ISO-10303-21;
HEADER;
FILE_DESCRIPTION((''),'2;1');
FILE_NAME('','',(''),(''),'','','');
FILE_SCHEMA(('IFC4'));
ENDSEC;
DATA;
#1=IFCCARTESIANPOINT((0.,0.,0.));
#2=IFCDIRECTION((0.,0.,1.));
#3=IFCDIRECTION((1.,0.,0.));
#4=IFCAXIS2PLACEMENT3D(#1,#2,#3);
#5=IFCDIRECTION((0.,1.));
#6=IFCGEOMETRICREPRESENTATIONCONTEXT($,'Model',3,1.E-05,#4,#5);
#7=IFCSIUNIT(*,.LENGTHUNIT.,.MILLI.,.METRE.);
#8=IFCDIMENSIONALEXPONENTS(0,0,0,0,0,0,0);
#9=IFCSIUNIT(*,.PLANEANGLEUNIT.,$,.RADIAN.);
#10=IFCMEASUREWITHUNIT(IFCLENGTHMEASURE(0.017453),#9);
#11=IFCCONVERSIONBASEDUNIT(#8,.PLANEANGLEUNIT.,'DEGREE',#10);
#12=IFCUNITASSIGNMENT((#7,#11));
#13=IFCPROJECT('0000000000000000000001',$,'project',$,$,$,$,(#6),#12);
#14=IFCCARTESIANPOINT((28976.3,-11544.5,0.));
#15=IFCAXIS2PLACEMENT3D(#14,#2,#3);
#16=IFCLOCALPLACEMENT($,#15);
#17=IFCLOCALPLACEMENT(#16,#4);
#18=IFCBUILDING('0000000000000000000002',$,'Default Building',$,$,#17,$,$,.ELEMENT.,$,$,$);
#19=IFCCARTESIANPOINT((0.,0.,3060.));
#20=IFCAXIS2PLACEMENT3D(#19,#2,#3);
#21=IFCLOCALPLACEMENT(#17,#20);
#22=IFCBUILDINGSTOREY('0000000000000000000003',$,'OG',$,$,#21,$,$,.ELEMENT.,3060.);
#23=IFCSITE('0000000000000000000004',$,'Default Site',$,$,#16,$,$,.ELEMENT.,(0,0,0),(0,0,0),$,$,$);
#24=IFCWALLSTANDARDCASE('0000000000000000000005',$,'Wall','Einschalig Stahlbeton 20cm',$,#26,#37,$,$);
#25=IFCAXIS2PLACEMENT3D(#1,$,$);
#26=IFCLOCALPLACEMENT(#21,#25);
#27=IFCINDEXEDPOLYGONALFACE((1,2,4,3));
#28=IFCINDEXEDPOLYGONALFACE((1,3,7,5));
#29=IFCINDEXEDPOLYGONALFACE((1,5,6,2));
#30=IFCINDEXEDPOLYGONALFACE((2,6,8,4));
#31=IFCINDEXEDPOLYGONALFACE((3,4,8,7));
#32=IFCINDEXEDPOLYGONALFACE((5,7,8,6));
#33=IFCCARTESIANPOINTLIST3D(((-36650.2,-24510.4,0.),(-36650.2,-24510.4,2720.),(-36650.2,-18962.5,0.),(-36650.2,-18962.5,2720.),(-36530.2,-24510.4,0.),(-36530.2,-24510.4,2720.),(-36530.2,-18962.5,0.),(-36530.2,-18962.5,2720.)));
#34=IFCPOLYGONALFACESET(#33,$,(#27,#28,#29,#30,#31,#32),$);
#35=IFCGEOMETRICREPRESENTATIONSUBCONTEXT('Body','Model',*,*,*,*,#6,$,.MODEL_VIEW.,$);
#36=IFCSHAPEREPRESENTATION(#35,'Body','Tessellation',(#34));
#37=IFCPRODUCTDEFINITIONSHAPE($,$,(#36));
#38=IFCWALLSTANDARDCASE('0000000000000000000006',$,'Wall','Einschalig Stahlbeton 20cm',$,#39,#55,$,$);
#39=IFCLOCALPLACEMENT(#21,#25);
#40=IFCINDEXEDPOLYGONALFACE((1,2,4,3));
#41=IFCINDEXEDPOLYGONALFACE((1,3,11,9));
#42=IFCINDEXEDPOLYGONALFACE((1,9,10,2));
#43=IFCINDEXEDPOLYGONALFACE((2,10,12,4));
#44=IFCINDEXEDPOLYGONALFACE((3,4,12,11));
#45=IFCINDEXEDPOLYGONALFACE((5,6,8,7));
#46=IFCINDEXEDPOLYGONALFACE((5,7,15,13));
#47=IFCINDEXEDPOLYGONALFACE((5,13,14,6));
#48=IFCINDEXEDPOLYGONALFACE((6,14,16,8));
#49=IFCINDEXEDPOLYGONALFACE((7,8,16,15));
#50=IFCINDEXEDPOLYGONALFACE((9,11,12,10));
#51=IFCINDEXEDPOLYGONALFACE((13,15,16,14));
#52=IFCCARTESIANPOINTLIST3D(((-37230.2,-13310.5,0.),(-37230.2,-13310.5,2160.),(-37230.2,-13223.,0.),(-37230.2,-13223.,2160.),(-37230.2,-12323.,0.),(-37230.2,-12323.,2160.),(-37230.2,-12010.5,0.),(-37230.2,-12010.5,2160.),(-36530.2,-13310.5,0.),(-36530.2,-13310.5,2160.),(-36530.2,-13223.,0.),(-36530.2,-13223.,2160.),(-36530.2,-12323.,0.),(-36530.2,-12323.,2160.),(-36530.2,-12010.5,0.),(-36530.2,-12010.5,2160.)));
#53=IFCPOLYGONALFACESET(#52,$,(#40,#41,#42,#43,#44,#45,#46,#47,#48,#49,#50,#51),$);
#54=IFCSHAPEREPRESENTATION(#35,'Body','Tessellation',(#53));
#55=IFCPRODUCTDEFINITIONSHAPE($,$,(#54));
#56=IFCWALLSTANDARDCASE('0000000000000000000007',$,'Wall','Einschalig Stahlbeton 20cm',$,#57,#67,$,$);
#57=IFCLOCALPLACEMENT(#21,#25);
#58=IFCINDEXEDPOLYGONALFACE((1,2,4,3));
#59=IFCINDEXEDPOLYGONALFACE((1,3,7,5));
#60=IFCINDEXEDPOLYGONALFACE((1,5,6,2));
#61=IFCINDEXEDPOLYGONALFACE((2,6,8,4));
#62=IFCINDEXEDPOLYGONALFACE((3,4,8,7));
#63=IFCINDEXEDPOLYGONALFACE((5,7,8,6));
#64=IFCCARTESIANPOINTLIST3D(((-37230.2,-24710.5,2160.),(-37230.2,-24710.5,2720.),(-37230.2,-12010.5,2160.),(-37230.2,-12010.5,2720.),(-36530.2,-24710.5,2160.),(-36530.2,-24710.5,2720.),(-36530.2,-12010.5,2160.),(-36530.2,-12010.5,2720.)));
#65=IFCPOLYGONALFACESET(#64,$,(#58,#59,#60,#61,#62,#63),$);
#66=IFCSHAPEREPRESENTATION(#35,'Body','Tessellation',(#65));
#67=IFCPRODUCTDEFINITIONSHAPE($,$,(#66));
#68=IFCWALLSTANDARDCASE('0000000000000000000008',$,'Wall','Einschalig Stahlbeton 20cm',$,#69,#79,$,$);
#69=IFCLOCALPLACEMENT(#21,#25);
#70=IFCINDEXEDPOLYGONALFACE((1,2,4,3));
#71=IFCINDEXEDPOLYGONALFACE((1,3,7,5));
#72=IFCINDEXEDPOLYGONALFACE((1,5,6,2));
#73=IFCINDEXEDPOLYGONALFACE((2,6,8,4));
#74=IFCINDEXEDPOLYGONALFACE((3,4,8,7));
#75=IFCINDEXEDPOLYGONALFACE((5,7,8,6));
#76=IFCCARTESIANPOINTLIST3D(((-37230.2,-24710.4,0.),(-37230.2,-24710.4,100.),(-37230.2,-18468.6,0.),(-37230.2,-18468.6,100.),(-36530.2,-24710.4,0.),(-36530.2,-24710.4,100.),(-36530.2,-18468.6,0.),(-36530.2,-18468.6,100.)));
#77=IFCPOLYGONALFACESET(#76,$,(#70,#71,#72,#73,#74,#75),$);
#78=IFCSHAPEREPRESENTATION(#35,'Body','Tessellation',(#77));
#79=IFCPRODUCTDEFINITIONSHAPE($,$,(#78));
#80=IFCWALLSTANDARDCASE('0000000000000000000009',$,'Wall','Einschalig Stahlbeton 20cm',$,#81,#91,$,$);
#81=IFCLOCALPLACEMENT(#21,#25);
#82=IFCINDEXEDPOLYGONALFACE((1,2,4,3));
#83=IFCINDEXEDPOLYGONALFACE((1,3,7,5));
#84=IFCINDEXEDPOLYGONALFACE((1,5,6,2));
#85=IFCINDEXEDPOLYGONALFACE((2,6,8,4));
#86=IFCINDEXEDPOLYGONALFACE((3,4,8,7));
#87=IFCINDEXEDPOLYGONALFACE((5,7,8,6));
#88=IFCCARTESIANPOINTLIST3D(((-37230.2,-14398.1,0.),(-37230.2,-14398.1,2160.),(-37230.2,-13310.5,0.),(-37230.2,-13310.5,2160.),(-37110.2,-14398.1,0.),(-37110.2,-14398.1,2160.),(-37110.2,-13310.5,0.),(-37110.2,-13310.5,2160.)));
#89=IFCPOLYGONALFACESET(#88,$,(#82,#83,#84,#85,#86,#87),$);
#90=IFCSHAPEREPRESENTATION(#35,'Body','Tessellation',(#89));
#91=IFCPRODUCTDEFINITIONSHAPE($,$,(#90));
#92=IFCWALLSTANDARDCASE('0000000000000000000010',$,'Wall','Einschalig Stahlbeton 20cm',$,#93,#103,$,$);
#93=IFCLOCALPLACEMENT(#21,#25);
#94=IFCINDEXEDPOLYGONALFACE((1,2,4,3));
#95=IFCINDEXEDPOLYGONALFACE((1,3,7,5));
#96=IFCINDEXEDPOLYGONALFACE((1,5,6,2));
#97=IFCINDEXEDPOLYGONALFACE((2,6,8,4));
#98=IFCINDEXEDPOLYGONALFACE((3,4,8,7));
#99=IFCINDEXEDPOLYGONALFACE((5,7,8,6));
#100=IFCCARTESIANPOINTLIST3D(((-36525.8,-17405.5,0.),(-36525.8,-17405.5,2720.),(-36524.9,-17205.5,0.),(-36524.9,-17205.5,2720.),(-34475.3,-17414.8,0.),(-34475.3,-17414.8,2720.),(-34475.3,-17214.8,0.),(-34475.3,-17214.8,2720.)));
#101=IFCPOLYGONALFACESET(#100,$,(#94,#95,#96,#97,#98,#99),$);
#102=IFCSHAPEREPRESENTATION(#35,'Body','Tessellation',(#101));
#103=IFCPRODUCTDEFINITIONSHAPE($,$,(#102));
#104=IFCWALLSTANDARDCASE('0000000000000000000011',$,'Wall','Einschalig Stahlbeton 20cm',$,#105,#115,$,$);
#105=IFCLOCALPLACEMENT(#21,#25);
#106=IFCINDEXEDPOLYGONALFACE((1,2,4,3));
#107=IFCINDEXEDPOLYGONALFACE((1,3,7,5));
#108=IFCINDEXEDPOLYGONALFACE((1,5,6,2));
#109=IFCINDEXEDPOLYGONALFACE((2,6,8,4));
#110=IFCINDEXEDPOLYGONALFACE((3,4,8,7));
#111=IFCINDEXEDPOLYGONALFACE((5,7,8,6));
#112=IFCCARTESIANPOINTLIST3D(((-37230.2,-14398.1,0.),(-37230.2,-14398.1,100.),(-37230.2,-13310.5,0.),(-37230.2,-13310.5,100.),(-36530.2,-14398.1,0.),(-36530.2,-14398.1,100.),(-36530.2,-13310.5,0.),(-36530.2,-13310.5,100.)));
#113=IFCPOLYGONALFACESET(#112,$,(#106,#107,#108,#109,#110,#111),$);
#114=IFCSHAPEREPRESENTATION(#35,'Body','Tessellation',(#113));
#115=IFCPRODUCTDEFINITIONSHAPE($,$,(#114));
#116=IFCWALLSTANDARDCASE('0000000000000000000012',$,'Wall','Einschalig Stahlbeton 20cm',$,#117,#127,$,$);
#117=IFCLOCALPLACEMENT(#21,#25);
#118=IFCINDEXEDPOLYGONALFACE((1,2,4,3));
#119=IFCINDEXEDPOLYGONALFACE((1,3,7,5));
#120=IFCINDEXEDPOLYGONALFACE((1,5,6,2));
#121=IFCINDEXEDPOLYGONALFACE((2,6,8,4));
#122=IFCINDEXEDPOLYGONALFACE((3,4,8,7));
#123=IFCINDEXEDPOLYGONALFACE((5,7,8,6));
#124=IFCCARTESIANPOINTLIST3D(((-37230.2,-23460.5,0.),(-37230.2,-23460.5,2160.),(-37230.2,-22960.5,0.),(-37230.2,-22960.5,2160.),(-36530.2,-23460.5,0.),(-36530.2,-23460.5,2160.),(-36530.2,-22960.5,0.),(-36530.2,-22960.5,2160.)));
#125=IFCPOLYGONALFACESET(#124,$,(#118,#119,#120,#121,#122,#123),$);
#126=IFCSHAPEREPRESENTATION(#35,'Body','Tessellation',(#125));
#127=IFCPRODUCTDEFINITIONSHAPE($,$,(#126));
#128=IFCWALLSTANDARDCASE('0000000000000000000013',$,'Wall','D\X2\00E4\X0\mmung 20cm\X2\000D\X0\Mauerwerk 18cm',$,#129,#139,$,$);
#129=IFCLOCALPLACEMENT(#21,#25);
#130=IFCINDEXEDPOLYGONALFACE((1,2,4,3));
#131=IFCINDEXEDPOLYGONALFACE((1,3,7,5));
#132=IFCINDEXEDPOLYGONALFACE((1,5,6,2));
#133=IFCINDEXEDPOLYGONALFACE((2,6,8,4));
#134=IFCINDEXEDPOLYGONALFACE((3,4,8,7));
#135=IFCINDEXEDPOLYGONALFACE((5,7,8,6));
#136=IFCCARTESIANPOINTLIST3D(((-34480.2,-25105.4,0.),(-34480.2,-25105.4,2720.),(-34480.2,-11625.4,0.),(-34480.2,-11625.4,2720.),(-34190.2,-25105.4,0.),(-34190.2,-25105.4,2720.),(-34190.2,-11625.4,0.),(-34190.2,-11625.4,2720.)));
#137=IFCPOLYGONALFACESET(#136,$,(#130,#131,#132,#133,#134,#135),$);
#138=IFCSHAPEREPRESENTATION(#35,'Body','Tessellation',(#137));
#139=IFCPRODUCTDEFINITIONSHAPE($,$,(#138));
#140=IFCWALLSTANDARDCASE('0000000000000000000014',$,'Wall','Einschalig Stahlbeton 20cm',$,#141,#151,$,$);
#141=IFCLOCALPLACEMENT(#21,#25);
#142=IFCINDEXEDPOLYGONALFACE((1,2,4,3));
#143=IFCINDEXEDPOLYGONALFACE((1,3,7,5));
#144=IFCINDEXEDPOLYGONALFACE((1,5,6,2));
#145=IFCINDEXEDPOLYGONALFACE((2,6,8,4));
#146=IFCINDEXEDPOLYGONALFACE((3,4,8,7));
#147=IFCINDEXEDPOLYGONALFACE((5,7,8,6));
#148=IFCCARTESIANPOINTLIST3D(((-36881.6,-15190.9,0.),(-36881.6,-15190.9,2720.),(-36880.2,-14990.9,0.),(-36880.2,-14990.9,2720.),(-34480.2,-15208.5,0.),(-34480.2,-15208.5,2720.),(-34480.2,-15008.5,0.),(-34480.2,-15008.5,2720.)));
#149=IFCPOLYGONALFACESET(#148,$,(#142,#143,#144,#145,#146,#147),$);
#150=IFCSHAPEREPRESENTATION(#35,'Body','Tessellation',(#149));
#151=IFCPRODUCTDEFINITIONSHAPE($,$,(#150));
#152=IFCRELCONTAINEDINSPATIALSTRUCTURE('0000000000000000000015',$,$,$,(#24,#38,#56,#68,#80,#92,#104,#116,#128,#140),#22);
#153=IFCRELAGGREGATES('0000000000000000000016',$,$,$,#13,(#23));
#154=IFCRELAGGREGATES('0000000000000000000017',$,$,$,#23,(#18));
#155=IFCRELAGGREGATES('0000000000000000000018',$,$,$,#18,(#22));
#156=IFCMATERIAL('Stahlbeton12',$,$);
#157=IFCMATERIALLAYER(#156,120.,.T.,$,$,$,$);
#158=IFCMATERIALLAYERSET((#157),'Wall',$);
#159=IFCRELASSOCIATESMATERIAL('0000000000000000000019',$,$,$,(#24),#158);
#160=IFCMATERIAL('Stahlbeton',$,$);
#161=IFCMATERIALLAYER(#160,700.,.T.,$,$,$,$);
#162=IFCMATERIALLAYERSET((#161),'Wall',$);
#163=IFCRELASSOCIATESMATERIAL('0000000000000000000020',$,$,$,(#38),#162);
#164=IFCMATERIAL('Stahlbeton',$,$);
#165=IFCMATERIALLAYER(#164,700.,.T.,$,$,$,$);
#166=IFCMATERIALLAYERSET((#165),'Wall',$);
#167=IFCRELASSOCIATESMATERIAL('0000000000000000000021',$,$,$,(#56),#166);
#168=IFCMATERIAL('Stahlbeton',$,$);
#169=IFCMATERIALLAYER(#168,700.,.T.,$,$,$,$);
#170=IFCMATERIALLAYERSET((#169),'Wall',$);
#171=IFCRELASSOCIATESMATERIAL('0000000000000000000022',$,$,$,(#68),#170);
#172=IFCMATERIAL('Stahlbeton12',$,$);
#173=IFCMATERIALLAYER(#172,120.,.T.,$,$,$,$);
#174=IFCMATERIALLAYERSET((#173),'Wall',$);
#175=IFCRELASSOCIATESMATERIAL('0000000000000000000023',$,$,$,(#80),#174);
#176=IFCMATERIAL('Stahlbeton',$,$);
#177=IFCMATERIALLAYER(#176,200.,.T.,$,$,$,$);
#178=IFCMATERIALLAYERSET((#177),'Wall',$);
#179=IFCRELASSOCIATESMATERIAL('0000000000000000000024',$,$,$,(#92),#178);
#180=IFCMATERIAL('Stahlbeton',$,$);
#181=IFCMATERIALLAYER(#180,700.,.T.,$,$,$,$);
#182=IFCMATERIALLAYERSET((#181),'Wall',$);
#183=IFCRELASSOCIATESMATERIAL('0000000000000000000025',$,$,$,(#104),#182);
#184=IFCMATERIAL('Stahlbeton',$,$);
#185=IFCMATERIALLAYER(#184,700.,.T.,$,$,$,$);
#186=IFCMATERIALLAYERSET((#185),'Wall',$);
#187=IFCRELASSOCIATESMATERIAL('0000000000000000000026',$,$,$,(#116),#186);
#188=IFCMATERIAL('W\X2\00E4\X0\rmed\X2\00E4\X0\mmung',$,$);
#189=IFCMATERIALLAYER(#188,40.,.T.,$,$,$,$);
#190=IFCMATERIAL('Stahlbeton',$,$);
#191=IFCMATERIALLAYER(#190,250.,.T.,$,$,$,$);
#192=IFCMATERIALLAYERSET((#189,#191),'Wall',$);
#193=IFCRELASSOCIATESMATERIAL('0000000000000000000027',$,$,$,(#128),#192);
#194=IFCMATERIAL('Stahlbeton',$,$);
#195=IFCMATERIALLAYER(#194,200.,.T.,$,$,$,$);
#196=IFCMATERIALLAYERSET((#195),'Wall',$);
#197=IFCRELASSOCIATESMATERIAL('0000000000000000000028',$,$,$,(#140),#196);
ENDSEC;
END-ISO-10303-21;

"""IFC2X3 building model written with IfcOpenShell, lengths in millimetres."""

from ifc_helpers import new_model, entity, si_unit, converted_unit, direction, frame, origin_with_axes, place, context, subcontext, project, spatial, polyline, outline, extrude, material, layer, layer_set, layer_usage, element, save


model = new_model("IFC2X3")

# Units and contexts
model_context = context("Model", 3, precision=1e-05, world=origin_with_axes(), true_north=direction((0.0, 1.0)))
body_context = subcontext(model_context, "Body", "Model", "MODEL_VIEW")
ifc_project = project(units=[si_unit("LENGTHUNIT", "METRE", prefix="MILLI"), converted_unit("PLANEANGLEUNIT", "DEGREE", entity("IfcLengthMeasure", 0.017453), si_unit("PLANEANGLEUNIT", "RADIAN"), dimensions=[0, 0, 0, 0, 0, 0, 0])], contexts=[model_context])

# Site, building, storey
site_placement = place(None, frame((28976.3, -11544.5, 0.0), z_axis=(0.0, 0.0, 1.0), x_axis=(1.0, 0.0, 0.0)))
site = spatial("IfcSite", under=ifc_project, at=site_placement, Name="Default Site", CompositionType="ELEMENT", RefLatitude=(0, 0, 0), RefLongitude=(0, 0, 0))
building_placement = place(site_placement, origin_with_axes())
building = spatial("IfcBuilding", under=site, at=building_placement, Name="Default Building", CompositionType="ELEMENT")
storey_placement = place(building_placement, frame((0.0, 0.0, 3060.0), z_axis=(0.0, 0.0, 1.0), x_axis=(1.0, 0.0, 0.0)))
storey = spatial("IfcBuildingStorey", under=building, at=storey_placement, Name="OG", CompositionType="ELEMENT", Elevation=3060.0)

# Wall
ifc_material_1 = material(Name="Stahlbeton12")
ifc_layer_1 = layer(ifc_material_1, 120.0, ventilated=True)
ifc_layer_set_1 = layer_set([ifc_layer_1], Name="Wall")
ifc_layer_usage_1 = layer_usage(ifc_layer_set_1, "AXIS2", "POSITIVE", -60.0)
wall_1_placement = place(storey_placement, frame((-36590.2, -24510.4, 0.0), z_axis=(0.0, 0.0, 1.0), x_axis=(0.0, 1.0, 0.0)))
element("IfcWallStandardCase", 1, at=wall_1_placement, inside=storey, material=ifc_layer_usage_1, Name="Wall", Description="Einschalig Stahlbeton 20cm", context=body_context, shape_type="SweptSolid", body=[
    extrude(outline(polyline([(0.0, -60.0), (0.0, 60.0), (5548.0, 60.0), (5548.0, -60.0), (0.0, -60.0)])), origin_with_axes(), (0.0, 0.0, 1.0), 2720.0),
])

# Wall, opening
ifc_material_2 = material(Name="Stahlbeton")
ifc_layer_2 = layer(ifc_material_2, 700.0, ventilated=True)
ifc_layer_set_2 = layer_set([ifc_layer_2], Name="Wall")
ifc_layer_usage_2 = layer_usage(ifc_layer_set_2, "AXIS2", "POSITIVE", -350.0)
wall_2_placement = place(storey_placement, frame((-36880.2, -13310.5, 0.0), z_axis=(0.0, 0.0, 1.0), x_axis=(0.0, 1.0, 0.0)))
wall_2 = element("IfcWallStandardCase", 2, at=wall_2_placement, inside=storey, material=ifc_layer_usage_2, Name="Wall", Description="Einschalig Stahlbeton 20cm", context=body_context, shape_type="SweptSolid", body=[
    extrude(outline(polyline([(0.0, -350.0), (0.0, 350.0), (1300.0, 350.0), (1300.0, -350.0), (0.0, -350.0)])), origin_with_axes(), (0.0, 0.0, 1.0), 2160.0),
])
opening_1_placement = place(wall_2_placement, frame((987.5, 0.0, 0.0), z_axis=(0.0, -1.0, 0.0), x_axis=(0.0, 0.0, 1.0)))
element("IfcOpeningElement", 3, at=opening_1_placement, cuts=wall_2, context=body_context, shape_type="SweptSolid", body=[
    extrude(outline(polyline([(0.0, 0.0), (2160.0, 0.0), (2160.0, 900.0), (0.0, 900.0), (0.0, 0.0), (0.0, 0.0)])), frame((0.0, 0.0, 700.0), z_axis=(0.0, 0.0, 1.0), x_axis=(1.0, 0.0, 0.0)), (0.0, 0.0, -1.0), 1400.0),
])

# Walls
ifc_material_3 = material(Name="Stahlbeton")
ifc_layer_3 = layer(ifc_material_3, 700.0, ventilated=True)
ifc_layer_set_3 = layer_set([ifc_layer_3], Name="Wall")
ifc_layer_usage_3 = layer_usage(ifc_layer_set_3, "AXIS2", "POSITIVE", -350.0)
wall_3_placement = place(storey_placement, frame((-36880.2, -12010.5, 2160.0), z_axis=(0.0, 0.0, 1.0), x_axis=(0.0, -1.0, 0.0)))
element("IfcWallStandardCase", 4, at=wall_3_placement, inside=storey, material=ifc_layer_usage_3, Name="Wall", Description="Einschalig Stahlbeton 20cm", context=body_context, shape_type="SweptSolid", body=[
    extrude(outline(polyline([(0.0, -350.0), (0.0, 350.0), (12700.0, 350.0), (12700.0, -350.0), (0.0, -350.0)])), origin_with_axes(), (0.0, 0.0, 1.0), 560.0),
])
ifc_material_4 = material(Name="Stahlbeton")
ifc_layer_4 = layer(ifc_material_4, 700.0, ventilated=True)
ifc_layer_set_4 = layer_set([ifc_layer_4], Name="Wall")
ifc_layer_usage_4 = layer_usage(ifc_layer_set_4, "AXIS2", "POSITIVE", -350.0)
wall_4_placement = place(storey_placement, frame((-36880.2, -24710.4, 0.0), z_axis=(0.0, 0.0, 1.0), x_axis=(0.0, 1.0, 0.0)))
element("IfcWallStandardCase", 5, at=wall_4_placement, inside=storey, material=ifc_layer_usage_4, Name="Wall", Description="Einschalig Stahlbeton 20cm", context=body_context, shape_type="SweptSolid", body=[
    extrude(outline(polyline([(0.0, -350.0), (0.0, 350.0), (6241.8, 350.0), (6241.8, -350.0), (0.0, -350.0)])), origin_with_axes(), (0.0, 0.0, 1.0), 100.0),
])
ifc_material_5 = material(Name="Stahlbeton12")
ifc_layer_5 = layer(ifc_material_5, 120.0, ventilated=True)
ifc_layer_set_5 = layer_set([ifc_layer_5], Name="Wall")
ifc_layer_usage_5 = layer_usage(ifc_layer_set_5, "AXIS2", "POSITIVE", -60.0)
wall_5_placement = place(storey_placement, frame((-37170.2, -13310.5, 0.0), z_axis=(0.0, 0.0, 1.0), x_axis=(0.0, -1.0, 0.0)))
element("IfcWallStandardCase", 6, at=wall_5_placement, inside=storey, material=ifc_layer_usage_5, Name="Wall", Description="Einschalig Stahlbeton 20cm", context=body_context, shape_type="SweptSolid", body=[
    extrude(outline(polyline([(0.0, -60.0), (0.0, 60.0), (1087.7, 60.0), (1087.7, -60.0), (0.0, -60.0)])), origin_with_axes(), (0.0, 0.0, 1.0), 2160.0),
])
ifc_material_6 = material(Name="Stahlbeton")
ifc_layer_6 = layer(ifc_material_6, 200.0, ventilated=True)
ifc_layer_set_6 = layer_set([ifc_layer_6], Name="Wall")
ifc_layer_usage_6 = layer_usage(ifc_layer_set_6, "AXIS2", "POSITIVE", -100.0)
wall_6_placement = place(storey_placement, frame((-36525.4, -17305.5, 0.0), z_axis=(0.0, 0.0, 1.0), x_axis=(0.99999, -0.004536, 0.0)))
element("IfcWallStandardCase", 7, at=wall_6_placement, inside=storey, material=ifc_layer_usage_6, Name="Wall", Description="Einschalig Stahlbeton 20cm", context=body_context, shape_type="SweptSolid", body=[
    extrude(outline(polyline([(2050.5, -100.0), (2049.6, 100.0), (0.0, 100.0), (0.0, -100.0), (2050.5, -100.0)])), origin_with_axes(), (0.0, 0.0, 1.0), 2720.0),
])
ifc_material_7 = material(Name="Stahlbeton")
ifc_layer_7 = layer(ifc_material_7, 700.0, ventilated=True)
ifc_layer_set_7 = layer_set([ifc_layer_7], Name="Wall")
ifc_layer_usage_7 = layer_usage(ifc_layer_set_7, "AXIS2", "POSITIVE", -350.0)
wall_7_placement = place(storey_placement, frame((-36880.2, -13310.5, 0.0), z_axis=(0.0, 0.0, 1.0), x_axis=(0.0, -1.0, 0.0)))
element("IfcWallStandardCase", 8, at=wall_7_placement, inside=storey, material=ifc_layer_usage_7, Name="Wall", Description="Einschalig Stahlbeton 20cm", context=body_context, shape_type="SweptSolid", body=[
    extrude(outline(polyline([(0.0, -350.0), (0.0, 350.0), (1087.7, 350.0), (1087.7, -350.0), (0.0, -350.0)])), origin_with_axes(), (0.0, 0.0, 1.0), 100.0),
])
ifc_material_8 = material(Name="Stahlbeton")
ifc_layer_8 = layer(ifc_material_8, 700.0, ventilated=True)
ifc_layer_set_8 = layer_set([ifc_layer_8], Name="Wall")
ifc_layer_usage_8 = layer_usage(ifc_layer_set_8, "AXIS2", "POSITIVE", -350.0)
wall_8_placement = place(storey_placement, frame((-36880.2, -23460.5, 0.0), z_axis=(0.0, 0.0, 1.0), x_axis=(0.0, 1.0, 0.0)))
element("IfcWallStandardCase", 9, at=wall_8_placement, inside=storey, material=ifc_layer_usage_8, Name="Wall", Description="Einschalig Stahlbeton 20cm", context=body_context, shape_type="SweptSolid", body=[
    extrude(outline(polyline([(0.0, -350.0), (0.0, 350.0), (500.0, 350.0), (500.0, -350.0), (0.0, -350.0)])), origin_with_axes(), (0.0, 0.0, 1.0), 2160.0),
])
ifc_material_9 = material(Name="Wärmedämmung")
ifc_layer_9 = layer(ifc_material_9, 40.0, ventilated=True)
ifc_material_10 = material(Name="Stahlbeton")
ifc_layer_10 = layer(ifc_material_10, 250.0, ventilated=True)
ifc_layer_set_9 = layer_set([ifc_layer_9, ifc_layer_10], Name="Wall")
ifc_layer_usage_9 = layer_usage(ifc_layer_set_9, "AXIS2", "POSITIVE", -145.0)
wall_9_placement = place(storey_placement, frame((-34335.2, -11625.4, 0.0), z_axis=(0.0, 0.0, 1.0), x_axis=(0.0, -1.0, 0.0)))
element("IfcWallStandardCase", 10, at=wall_9_placement, inside=storey, material=ifc_layer_usage_9, Name="Wall", Description="Dämmung 20cm\rMauerwerk 18cm", context=body_context, shape_type="SweptSolid", body=[
    extrude(outline(polyline([(0.0, -145.0), (0.0, 145.0), (13480.0, 145.0), (13480.0, -145.0), (0.0, -145.0)])), origin_with_axes(), (0.0, 0.0, 1.0), 2720.0),
])
ifc_material_11 = material(Name="Stahlbeton")
ifc_layer_11 = layer(ifc_material_11, 200.0, ventilated=True)
ifc_layer_set_10 = layer_set([ifc_layer_11], Name="Wall")
ifc_layer_usage_10 = layer_usage(ifc_layer_set_10, "AXIS2", "POSITIVE", -100.0)
wall_10_placement = place(storey_placement, frame((-36880.9, -15090.9, 0.0), z_axis=(0.0, 0.0, 1.0), x_axis=(0.999973, -0.007317, 0.0)))
element("IfcWallStandardCase", 11, at=wall_10_placement, inside=storey, material=ifc_layer_usage_10, Name="Wall", Description="Einschalig Stahlbeton 20cm", context=body_context, shape_type="SweptSolid", body=[
    extrude(outline(polyline([(2401.5, -100.0), (2400.1, 100.0), (0.0, 100.0), (0.0, -100.0), (2401.5, -100.0)])), origin_with_axes(), (0.0, 0.0, 1.0), 2720.0),
])

save(model, "model.ifc")
